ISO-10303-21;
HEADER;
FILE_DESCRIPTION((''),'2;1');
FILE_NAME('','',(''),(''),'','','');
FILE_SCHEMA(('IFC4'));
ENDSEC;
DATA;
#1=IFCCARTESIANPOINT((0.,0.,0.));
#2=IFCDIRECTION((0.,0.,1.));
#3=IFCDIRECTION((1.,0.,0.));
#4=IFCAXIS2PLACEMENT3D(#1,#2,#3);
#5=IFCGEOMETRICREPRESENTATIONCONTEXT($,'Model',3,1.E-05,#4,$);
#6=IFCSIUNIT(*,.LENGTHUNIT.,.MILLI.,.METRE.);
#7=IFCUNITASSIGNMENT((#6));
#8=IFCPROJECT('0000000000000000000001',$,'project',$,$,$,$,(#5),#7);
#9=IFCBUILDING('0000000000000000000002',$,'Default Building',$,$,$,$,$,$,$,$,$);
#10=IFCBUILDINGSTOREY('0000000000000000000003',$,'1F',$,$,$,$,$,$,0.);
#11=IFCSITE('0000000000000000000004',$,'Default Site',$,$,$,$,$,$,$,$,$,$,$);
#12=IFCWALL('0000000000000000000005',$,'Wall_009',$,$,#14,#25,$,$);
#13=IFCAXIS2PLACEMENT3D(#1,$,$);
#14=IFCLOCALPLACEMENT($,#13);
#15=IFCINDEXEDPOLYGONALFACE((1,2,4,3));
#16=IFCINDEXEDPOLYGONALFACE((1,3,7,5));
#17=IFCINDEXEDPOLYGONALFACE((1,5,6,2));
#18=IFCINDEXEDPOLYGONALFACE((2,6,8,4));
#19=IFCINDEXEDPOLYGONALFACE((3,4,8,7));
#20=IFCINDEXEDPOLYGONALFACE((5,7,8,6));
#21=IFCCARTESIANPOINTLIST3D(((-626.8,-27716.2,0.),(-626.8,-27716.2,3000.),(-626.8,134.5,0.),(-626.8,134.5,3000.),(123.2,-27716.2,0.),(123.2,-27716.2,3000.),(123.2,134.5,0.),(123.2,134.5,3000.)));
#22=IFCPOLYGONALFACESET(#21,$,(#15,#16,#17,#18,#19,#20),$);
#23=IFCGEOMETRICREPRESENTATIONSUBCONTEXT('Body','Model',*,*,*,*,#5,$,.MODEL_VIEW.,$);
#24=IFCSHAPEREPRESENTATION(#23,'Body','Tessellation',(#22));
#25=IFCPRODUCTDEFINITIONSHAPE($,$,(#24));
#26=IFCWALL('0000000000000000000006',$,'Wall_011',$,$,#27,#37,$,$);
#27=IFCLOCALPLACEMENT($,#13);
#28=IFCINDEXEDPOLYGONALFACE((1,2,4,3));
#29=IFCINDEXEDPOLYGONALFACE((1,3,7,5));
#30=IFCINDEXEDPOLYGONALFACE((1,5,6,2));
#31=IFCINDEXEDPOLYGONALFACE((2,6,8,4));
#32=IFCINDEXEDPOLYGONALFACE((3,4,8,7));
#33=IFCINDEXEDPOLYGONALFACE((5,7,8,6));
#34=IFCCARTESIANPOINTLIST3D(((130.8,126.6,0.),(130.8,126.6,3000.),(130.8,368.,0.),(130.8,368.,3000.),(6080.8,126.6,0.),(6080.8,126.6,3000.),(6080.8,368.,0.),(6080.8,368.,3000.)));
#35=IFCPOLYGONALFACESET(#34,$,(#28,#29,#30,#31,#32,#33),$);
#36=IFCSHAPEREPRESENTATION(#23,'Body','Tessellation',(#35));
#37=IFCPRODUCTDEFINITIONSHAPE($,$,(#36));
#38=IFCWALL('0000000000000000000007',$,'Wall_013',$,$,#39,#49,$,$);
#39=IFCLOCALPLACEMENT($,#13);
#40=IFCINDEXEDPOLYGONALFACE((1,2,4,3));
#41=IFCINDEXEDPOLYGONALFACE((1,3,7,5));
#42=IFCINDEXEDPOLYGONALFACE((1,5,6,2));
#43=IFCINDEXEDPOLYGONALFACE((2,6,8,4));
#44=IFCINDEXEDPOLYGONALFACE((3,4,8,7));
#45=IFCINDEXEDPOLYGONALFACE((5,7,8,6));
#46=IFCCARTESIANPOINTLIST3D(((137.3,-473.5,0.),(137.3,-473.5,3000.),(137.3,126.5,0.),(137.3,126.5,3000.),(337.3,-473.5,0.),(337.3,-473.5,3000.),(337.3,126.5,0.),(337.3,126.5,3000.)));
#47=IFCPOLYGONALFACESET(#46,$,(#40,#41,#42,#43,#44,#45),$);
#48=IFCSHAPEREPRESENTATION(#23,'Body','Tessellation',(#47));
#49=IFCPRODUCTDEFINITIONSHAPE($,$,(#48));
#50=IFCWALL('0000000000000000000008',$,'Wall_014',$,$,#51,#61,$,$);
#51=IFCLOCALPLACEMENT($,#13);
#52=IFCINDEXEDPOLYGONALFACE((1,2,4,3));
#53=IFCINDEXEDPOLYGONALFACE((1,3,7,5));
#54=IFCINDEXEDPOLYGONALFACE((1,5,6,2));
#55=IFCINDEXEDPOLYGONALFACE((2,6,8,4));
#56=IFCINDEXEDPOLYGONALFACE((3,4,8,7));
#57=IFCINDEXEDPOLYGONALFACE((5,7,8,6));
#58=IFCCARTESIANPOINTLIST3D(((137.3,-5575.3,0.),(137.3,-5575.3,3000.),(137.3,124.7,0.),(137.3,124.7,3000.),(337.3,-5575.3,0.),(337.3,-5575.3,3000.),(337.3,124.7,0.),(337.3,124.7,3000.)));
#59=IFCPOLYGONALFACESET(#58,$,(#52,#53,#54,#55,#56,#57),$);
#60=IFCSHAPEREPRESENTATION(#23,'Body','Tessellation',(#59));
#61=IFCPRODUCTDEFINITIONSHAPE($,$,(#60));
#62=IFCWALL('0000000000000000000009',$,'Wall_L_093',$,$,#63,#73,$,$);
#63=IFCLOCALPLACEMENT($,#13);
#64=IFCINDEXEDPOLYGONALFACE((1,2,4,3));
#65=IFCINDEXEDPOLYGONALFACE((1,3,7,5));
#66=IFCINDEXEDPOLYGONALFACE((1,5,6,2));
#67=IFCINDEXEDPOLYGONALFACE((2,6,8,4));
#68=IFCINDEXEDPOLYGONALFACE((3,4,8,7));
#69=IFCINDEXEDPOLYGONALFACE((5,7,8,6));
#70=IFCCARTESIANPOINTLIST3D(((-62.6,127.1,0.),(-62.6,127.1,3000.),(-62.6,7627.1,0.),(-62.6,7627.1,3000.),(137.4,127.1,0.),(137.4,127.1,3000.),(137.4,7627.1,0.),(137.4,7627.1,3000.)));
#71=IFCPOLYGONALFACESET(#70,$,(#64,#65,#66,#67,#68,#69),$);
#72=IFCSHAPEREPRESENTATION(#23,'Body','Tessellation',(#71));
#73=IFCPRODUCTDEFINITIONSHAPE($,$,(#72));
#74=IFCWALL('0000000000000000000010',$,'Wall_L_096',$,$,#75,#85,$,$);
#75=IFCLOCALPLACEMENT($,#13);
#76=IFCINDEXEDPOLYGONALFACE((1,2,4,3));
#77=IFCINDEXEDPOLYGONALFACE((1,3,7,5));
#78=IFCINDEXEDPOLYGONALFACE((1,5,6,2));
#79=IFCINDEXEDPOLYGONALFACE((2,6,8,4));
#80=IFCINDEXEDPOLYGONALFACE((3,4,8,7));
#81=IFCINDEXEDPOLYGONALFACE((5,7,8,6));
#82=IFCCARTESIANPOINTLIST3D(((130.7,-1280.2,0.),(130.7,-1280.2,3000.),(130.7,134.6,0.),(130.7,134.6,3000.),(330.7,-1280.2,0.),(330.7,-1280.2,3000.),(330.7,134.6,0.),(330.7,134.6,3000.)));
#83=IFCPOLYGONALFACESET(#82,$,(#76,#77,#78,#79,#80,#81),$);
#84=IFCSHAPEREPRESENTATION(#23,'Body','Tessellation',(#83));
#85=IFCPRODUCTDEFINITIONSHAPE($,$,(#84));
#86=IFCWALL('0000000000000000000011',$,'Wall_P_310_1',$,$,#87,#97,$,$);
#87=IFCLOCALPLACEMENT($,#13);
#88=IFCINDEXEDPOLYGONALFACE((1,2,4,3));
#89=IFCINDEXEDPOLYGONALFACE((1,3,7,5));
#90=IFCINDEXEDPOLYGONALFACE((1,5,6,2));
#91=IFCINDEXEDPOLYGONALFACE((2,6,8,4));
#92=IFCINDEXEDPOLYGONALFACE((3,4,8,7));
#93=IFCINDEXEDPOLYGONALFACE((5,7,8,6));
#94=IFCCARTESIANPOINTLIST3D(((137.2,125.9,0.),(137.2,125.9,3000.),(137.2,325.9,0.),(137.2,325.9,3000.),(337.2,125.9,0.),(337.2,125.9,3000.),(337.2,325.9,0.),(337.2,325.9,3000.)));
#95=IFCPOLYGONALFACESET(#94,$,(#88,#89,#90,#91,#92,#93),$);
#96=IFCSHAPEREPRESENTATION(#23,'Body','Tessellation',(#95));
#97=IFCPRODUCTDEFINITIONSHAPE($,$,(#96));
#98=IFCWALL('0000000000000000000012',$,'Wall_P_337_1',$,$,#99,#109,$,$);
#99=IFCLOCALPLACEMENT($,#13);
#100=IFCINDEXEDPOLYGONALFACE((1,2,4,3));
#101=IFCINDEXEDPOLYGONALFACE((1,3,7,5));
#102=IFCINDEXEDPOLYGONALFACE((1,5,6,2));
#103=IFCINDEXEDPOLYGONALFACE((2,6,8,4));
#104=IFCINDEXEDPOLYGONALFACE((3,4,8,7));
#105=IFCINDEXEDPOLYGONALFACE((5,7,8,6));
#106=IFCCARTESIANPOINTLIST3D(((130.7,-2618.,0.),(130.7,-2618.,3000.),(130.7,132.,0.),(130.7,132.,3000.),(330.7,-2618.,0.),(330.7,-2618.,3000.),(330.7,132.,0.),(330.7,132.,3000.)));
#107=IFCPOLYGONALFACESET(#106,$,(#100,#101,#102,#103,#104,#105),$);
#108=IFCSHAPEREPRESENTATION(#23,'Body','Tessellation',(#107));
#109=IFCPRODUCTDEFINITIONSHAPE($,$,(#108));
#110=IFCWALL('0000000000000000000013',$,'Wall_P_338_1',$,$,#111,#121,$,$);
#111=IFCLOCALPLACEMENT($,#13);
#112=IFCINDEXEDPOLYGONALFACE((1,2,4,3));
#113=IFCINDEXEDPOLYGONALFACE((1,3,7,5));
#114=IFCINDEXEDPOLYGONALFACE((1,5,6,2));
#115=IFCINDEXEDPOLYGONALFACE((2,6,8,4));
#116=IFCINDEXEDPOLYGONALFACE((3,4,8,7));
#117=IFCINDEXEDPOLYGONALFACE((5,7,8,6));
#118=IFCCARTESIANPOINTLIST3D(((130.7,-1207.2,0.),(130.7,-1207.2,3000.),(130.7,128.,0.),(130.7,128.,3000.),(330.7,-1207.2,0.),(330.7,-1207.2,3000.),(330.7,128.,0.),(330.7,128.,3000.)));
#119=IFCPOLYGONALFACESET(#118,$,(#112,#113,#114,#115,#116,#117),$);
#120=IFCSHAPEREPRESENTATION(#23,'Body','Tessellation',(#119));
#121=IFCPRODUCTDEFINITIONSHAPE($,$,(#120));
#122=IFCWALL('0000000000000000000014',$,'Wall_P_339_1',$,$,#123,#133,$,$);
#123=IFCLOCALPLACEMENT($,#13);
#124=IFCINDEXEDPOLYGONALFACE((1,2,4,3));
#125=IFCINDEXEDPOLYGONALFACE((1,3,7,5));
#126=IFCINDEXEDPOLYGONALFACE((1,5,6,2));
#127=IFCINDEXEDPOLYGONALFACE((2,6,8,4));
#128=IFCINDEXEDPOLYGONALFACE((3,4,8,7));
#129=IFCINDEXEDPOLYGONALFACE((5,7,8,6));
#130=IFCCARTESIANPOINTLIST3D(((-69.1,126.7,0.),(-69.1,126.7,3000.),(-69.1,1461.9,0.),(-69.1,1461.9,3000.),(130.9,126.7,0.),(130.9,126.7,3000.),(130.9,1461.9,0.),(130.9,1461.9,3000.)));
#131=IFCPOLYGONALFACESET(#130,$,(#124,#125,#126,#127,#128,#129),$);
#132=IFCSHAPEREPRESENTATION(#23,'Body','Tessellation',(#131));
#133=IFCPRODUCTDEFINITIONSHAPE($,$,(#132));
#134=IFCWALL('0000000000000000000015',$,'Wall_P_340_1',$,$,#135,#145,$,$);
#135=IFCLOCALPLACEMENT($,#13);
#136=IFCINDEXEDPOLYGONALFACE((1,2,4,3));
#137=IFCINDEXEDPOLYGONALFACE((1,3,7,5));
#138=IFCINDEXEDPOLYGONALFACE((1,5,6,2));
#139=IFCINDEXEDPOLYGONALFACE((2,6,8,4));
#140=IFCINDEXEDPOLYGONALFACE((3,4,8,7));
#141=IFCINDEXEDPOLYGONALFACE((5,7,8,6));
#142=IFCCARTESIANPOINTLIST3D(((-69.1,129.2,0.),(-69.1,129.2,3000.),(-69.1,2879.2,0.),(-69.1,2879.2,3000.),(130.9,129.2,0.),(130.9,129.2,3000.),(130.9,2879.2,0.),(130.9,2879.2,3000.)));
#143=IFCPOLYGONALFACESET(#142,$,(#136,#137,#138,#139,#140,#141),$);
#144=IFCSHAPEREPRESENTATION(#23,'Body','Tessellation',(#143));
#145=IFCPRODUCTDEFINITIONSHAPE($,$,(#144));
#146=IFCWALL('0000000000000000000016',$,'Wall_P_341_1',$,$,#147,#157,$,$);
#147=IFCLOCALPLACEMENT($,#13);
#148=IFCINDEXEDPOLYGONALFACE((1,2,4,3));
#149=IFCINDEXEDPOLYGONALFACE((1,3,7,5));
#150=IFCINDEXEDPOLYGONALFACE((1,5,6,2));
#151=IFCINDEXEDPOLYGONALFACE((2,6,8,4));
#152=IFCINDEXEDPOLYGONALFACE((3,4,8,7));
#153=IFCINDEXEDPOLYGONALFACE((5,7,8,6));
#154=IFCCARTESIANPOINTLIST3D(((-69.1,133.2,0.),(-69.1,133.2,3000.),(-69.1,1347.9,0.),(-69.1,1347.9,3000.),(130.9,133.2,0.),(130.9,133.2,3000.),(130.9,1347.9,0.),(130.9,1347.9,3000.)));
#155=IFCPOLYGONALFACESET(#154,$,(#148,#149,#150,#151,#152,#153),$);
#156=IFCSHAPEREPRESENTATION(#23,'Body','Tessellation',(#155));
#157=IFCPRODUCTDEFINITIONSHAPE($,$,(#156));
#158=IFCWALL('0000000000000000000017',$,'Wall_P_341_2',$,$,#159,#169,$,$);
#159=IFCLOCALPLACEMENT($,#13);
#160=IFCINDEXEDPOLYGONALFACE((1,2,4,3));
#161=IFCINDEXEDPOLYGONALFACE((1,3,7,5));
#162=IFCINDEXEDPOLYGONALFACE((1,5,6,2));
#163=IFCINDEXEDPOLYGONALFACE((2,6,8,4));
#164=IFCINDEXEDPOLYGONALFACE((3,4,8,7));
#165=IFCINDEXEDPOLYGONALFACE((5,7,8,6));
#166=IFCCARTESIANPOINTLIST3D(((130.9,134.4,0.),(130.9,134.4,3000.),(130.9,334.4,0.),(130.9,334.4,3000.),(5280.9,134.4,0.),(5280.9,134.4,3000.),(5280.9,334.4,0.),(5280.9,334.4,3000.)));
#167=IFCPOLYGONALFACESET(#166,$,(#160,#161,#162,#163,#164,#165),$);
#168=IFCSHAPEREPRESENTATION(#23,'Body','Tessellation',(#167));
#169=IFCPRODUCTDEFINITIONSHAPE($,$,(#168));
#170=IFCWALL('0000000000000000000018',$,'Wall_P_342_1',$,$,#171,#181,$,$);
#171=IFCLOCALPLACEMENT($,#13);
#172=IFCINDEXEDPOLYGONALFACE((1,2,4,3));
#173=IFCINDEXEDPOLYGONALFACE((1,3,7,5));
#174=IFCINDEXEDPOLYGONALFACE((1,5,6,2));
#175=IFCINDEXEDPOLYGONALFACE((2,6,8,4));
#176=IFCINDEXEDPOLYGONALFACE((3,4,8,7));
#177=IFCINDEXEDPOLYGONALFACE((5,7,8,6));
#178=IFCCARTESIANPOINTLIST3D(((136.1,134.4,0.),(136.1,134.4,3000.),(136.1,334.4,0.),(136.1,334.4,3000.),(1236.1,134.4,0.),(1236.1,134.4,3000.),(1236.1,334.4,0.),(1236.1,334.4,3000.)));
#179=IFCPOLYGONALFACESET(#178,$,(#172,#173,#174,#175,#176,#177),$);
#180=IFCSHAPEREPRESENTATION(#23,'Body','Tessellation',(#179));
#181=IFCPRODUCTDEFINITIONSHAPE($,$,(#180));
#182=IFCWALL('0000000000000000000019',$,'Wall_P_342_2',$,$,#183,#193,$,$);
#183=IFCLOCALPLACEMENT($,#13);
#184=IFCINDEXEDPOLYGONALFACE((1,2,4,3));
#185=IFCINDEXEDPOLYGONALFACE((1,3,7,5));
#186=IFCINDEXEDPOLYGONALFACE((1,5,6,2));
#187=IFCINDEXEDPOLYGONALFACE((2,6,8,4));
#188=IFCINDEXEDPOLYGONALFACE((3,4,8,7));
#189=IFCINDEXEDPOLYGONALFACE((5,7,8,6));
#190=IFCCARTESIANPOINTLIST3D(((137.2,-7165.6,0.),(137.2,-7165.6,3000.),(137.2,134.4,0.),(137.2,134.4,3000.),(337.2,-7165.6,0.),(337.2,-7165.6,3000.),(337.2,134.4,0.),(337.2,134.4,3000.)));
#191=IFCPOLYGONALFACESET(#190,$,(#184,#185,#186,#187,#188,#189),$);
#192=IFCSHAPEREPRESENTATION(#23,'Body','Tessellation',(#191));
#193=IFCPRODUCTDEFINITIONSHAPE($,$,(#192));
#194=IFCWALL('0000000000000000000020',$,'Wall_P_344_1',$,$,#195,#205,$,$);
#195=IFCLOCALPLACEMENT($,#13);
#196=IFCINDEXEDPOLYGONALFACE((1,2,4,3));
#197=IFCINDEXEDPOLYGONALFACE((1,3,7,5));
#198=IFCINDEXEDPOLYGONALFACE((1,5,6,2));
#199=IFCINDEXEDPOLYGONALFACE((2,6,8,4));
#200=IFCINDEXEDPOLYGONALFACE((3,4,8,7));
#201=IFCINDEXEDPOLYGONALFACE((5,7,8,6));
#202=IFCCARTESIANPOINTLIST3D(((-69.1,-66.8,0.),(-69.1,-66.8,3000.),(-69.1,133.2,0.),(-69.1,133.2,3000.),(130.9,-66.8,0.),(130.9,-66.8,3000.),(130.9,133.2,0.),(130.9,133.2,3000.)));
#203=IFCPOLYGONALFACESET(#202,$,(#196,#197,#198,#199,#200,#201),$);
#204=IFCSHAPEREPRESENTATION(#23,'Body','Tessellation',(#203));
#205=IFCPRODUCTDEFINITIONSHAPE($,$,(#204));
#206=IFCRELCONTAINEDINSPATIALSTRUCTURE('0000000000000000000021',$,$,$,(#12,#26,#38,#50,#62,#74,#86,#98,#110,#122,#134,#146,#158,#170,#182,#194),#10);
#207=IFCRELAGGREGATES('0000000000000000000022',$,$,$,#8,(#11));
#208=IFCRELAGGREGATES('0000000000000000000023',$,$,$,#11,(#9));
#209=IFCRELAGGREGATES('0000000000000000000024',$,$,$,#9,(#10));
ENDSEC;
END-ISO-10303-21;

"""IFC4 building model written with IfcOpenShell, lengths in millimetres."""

from ifc_helpers import new_model, si_unit, frame, origin_with_axes, place, context, subcontext, project, spatial, indexed_curve, outline, extrude, element, save


model = new_model("IFC4")

# Units and contexts
model_context = context("Model", 3, precision=1e-05, world=origin_with_axes())
body_context = subcontext(model_context, "Body", "Model", "MODEL_VIEW")
ifc_project = project(units=[si_unit("LENGTHUNIT", "METRE", prefix="MILLI")], contexts=[model_context])

# Site, building, storey
site = spatial("IfcSite", under=ifc_project, Name="Default Site")
building = spatial("IfcBuilding", under=site, Name="Default Building")
storey = spatial("IfcBuildingStorey", under=building, Name="1F", Elevation=0.0)

# Walls
wall_1_placement = place(None, frame((123.2, 134.5, 0.0), z_axis=(0.0, 0.0, 1.0), x_axis=(-1.0, 0.0, 0.0)))
element("IfcWall", 1, at=wall_1_placement, inside=storey, Name="Wall_009", context=body_context, shape_type="SweptSolid", body=[
    extrude(outline(indexed_curve([(0.0, 0.0), (0.0, 27850.7), (750.0, 27850.7), (750.0, 0.0), (0.0, 0.0)], self_intersect=False)), origin_with_axes(), (0.0, 0.0, 1.0), 3000.0),
])
wall_2_placement = place(None, frame((130.8, 126.6, 0.0), z_axis=(0.0, 0.0, 1.0), x_axis=(1.0, 0.0, 0.0)))
element("IfcWall", 2, at=wall_2_placement, inside=storey, Name="Wall_011", context=body_context, shape_type="SweptSolid", body=[
    extrude(outline(indexed_curve([(0.0, 0.0), (0.0, 241.4), (5950.0, 241.4), (5950.0, 0.0), (0.0, 0.0)], self_intersect=False)), origin_with_axes(), (0.0, 0.0, 1.0), 3000.0),
])
wall_3_placement = place(None, frame((137.3, 126.5, 0.0), z_axis=(0.0, 0.0, 1.0), x_axis=(0.0, -1.0, 0.0)))
element("IfcWall", 3, at=wall_3_placement, inside=storey, Name="Wall_013", context=body_context, shape_type="SweptSolid", body=[
    extrude(outline(indexed_curve([(0.0, 0.0), (0.0, 200.0), (600.0, 200.0), (600.0, 0.0), (0.0, 0.0)], self_intersect=False)), origin_with_axes(), (0.0, 0.0, 1.0), 3000.0),
])
wall_4_placement = place(None, frame((137.3, 124.7, 0.0), z_axis=(0.0, 0.0, 1.0), x_axis=(0.0, -1.0, 0.0)))
element("IfcWall", 4, at=wall_4_placement, inside=storey, Name="Wall_014", context=body_context, shape_type="SweptSolid", body=[
    extrude(outline(indexed_curve([(0.0, 0.0), (0.0, 200.0), (5700.0, 200.0), (5700.0, 0.0), (0.0, 0.0)], self_intersect=False)), origin_with_axes(), (0.0, 0.0, 1.0), 3000.0),
])
wall_5_placement = place(None, frame((137.4, 127.1, 0.0), z_axis=(0.0, 0.0, 1.0), x_axis=(0.0, 1.0, 0.0)))
element("IfcWall", 5, at=wall_5_placement, inside=storey, Name="Wall_L_093", context=body_context, shape_type="SweptSolid", body=[
    extrude(outline(indexed_curve([(0.0, 0.0), (0.0, 200.0), (7500.0, 200.0), (7500.0, 0.0), (0.0, 0.0)], self_intersect=False)), origin_with_axes(), (0.0, 0.0, 1.0), 3000.0),
])
wall_6_placement = place(None, frame((130.7, 134.6, 0.0), z_axis=(0.0, 0.0, 1.0), x_axis=(0.0, -1.0, 0.0)))
element("IfcWall", 6, at=wall_6_placement, inside=storey, Name="Wall_L_096", context=body_context, shape_type="SweptSolid", body=[
    extrude(outline(indexed_curve([(0.0, 0.0), (0.0, 200.0), (1414.8, 200.0), (1414.8, 0.0), (0.0, 0.0)], self_intersect=False)), origin_with_axes(), (0.0, 0.0, 1.0), 3000.0),
])
wall_7_placement = place(None, frame((137.2, 125.9, 0.0), z_axis=(0.0, 0.0, 1.0), x_axis=(1.0, 0.0, 0.0)))
element("IfcWall", 7, at=wall_7_placement, inside=storey, Name="Wall_P_310_1", context=body_context, shape_type="SweptSolid", body=[
    extrude(outline(indexed_curve([(0.0, 0.0), (0.0, 200.0), (200.0, 200.0), (200.0, 0.0), (0.0, 0.0)], self_intersect=False)), origin_with_axes(), (0.0, 0.0, 1.0), 3000.0),
])
wall_8_placement = place(None, frame((130.7, 132.0, 0.0), z_axis=(0.0, 0.0, 1.0), x_axis=(0.0, -1.0, 0.0)))
element("IfcWall", 8, at=wall_8_placement, inside=storey, Name="Wall_P_337_1", context=body_context, shape_type="SweptSolid", body=[
    extrude(outline(indexed_curve([(0.0, 0.0), (0.0, 200.0), (2750.0, 200.0), (2750.0, 0.0), (0.0, 0.0)], self_intersect=False)), origin_with_axes(), (0.0, 0.0, 1.0), 3000.0),
])
for number, where, z_axis, x_axis, name in (
    (9, (130.7, 128.0, 0.0), (0.0, 0.0, 1.0), (0.0, -1.0, 0.0), "Wall_P_338_1"),
    (10, (130.9, 126.7, 0.0), (0.0, 0.0, 1.0), (0.0, 1.0, 0.0), "Wall_P_339_1"),
):
    element("IfcWall", number, at=place(None, frame(where, z_axis=z_axis, x_axis=x_axis)), inside=storey, Name=name, context=body_context, shape_type="SweptSolid", body=[
        extrude(outline(indexed_curve([(0.0, 0.0), (0.0, 200.0), (1335.2, 200.0), (1335.2, 0.0), (0.0, 0.0)], self_intersect=False)), origin_with_axes(), (0.0, 0.0, 1.0), 3000.0),
    ])
wall_9_placement = place(None, frame((130.9, 129.2, 0.0), z_axis=(0.0, 0.0, 1.0), x_axis=(0.0, 1.0, 0.0)))
element("IfcWall", 11, at=wall_9_placement, inside=storey, Name="Wall_P_340_1", context=body_context, shape_type="SweptSolid", body=[
    extrude(outline(indexed_curve([(0.0, 0.0), (0.0, 200.0), (2750.0, 200.0), (2750.0, 0.0), (0.0, 0.0)], self_intersect=False)), origin_with_axes(), (0.0, 0.0, 1.0), 3000.0),
])
wall_10_placement = place(None, frame((130.9, 133.2, 0.0), z_axis=(0.0, 0.0, 1.0), x_axis=(0.0, 1.0, 0.0)))
element("IfcWall", 12, at=wall_10_placement, inside=storey, Name="Wall_P_341_1", context=body_context, shape_type="SweptSolid", body=[
    extrude(outline(indexed_curve([(0.0, 0.0), (0.0, 200.0), (1214.8, 200.0), (1214.8, 0.0), (0.0, 0.0)], self_intersect=False)), origin_with_axes(), (0.0, 0.0, 1.0), 3000.0),
])
wall_11_placement = place(None, frame((130.9, 134.4, 0.0), z_axis=(0.0, 0.0, 1.0), x_axis=(1.0, 0.0, 0.0)))
element("IfcWall", 13, at=wall_11_placement, inside=storey, Name="Wall_P_341_2", context=body_context, shape_type="SweptSolid", body=[
    extrude(outline(indexed_curve([(0.0, 0.0), (0.0, 200.0), (5150.0, 200.0), (5150.0, 0.0), (0.0, 0.0)], self_intersect=False)), origin_with_axes(), (0.0, 0.0, 1.0), 3000.0),
])
wall_12_placement = place(None, frame((136.1, 134.4, 0.0), z_axis=(0.0, 0.0, 1.0), x_axis=(1.0, 0.0, 0.0)))
element("IfcWall", 14, at=wall_12_placement, inside=storey, Name="Wall_P_342_1", context=body_context, shape_type="SweptSolid", body=[
    extrude(outline(indexed_curve([(0.0, 0.0), (0.0, 200.0), (1100.0, 200.0), (1100.0, 0.0), (0.0, 0.0)], self_intersect=False)), origin_with_axes(), (0.0, 0.0, 1.0), 3000.0),
])
wall_13_placement = place(None, frame((137.2, 134.4, 0.0), z_axis=(0.0, 0.0, 1.0), x_axis=(0.0, -1.0, 0.0)))
element("IfcWall", 15, at=wall_13_placement, inside=storey, Name="Wall_P_342_2", context=body_context, shape_type="SweptSolid", body=[
    extrude(outline(indexed_curve([(0.0, 0.0), (0.0, 200.0), (7300.0, 200.0), (7300.0, 0.0), (0.0, 0.0)], self_intersect=False)), origin_with_axes(), (0.0, 0.0, 1.0), 3000.0),
])
for number, where, z_axis, x_axis, name in (
    (16, (130.9, 133.2, 0.0), (0.0, 0.0, 1.0), (-1.0, 0.0, 0.0), "Wall_P_344_1"),
):
    element("IfcWall", number, at=place(None, frame(where, z_axis=z_axis, x_axis=x_axis)), inside=storey, Name=name, context=body_context, shape_type="SweptSolid", body=[
        extrude(outline(indexed_curve([(0.0, 0.0), (0.0, 200.0), (200.0, 200.0), (200.0, 0.0), (0.0, 0.0)], self_intersect=False)), origin_with_axes(), (0.0, 0.0, 1.0), 3000.0),
    ])

save(model, "model.ifc")
